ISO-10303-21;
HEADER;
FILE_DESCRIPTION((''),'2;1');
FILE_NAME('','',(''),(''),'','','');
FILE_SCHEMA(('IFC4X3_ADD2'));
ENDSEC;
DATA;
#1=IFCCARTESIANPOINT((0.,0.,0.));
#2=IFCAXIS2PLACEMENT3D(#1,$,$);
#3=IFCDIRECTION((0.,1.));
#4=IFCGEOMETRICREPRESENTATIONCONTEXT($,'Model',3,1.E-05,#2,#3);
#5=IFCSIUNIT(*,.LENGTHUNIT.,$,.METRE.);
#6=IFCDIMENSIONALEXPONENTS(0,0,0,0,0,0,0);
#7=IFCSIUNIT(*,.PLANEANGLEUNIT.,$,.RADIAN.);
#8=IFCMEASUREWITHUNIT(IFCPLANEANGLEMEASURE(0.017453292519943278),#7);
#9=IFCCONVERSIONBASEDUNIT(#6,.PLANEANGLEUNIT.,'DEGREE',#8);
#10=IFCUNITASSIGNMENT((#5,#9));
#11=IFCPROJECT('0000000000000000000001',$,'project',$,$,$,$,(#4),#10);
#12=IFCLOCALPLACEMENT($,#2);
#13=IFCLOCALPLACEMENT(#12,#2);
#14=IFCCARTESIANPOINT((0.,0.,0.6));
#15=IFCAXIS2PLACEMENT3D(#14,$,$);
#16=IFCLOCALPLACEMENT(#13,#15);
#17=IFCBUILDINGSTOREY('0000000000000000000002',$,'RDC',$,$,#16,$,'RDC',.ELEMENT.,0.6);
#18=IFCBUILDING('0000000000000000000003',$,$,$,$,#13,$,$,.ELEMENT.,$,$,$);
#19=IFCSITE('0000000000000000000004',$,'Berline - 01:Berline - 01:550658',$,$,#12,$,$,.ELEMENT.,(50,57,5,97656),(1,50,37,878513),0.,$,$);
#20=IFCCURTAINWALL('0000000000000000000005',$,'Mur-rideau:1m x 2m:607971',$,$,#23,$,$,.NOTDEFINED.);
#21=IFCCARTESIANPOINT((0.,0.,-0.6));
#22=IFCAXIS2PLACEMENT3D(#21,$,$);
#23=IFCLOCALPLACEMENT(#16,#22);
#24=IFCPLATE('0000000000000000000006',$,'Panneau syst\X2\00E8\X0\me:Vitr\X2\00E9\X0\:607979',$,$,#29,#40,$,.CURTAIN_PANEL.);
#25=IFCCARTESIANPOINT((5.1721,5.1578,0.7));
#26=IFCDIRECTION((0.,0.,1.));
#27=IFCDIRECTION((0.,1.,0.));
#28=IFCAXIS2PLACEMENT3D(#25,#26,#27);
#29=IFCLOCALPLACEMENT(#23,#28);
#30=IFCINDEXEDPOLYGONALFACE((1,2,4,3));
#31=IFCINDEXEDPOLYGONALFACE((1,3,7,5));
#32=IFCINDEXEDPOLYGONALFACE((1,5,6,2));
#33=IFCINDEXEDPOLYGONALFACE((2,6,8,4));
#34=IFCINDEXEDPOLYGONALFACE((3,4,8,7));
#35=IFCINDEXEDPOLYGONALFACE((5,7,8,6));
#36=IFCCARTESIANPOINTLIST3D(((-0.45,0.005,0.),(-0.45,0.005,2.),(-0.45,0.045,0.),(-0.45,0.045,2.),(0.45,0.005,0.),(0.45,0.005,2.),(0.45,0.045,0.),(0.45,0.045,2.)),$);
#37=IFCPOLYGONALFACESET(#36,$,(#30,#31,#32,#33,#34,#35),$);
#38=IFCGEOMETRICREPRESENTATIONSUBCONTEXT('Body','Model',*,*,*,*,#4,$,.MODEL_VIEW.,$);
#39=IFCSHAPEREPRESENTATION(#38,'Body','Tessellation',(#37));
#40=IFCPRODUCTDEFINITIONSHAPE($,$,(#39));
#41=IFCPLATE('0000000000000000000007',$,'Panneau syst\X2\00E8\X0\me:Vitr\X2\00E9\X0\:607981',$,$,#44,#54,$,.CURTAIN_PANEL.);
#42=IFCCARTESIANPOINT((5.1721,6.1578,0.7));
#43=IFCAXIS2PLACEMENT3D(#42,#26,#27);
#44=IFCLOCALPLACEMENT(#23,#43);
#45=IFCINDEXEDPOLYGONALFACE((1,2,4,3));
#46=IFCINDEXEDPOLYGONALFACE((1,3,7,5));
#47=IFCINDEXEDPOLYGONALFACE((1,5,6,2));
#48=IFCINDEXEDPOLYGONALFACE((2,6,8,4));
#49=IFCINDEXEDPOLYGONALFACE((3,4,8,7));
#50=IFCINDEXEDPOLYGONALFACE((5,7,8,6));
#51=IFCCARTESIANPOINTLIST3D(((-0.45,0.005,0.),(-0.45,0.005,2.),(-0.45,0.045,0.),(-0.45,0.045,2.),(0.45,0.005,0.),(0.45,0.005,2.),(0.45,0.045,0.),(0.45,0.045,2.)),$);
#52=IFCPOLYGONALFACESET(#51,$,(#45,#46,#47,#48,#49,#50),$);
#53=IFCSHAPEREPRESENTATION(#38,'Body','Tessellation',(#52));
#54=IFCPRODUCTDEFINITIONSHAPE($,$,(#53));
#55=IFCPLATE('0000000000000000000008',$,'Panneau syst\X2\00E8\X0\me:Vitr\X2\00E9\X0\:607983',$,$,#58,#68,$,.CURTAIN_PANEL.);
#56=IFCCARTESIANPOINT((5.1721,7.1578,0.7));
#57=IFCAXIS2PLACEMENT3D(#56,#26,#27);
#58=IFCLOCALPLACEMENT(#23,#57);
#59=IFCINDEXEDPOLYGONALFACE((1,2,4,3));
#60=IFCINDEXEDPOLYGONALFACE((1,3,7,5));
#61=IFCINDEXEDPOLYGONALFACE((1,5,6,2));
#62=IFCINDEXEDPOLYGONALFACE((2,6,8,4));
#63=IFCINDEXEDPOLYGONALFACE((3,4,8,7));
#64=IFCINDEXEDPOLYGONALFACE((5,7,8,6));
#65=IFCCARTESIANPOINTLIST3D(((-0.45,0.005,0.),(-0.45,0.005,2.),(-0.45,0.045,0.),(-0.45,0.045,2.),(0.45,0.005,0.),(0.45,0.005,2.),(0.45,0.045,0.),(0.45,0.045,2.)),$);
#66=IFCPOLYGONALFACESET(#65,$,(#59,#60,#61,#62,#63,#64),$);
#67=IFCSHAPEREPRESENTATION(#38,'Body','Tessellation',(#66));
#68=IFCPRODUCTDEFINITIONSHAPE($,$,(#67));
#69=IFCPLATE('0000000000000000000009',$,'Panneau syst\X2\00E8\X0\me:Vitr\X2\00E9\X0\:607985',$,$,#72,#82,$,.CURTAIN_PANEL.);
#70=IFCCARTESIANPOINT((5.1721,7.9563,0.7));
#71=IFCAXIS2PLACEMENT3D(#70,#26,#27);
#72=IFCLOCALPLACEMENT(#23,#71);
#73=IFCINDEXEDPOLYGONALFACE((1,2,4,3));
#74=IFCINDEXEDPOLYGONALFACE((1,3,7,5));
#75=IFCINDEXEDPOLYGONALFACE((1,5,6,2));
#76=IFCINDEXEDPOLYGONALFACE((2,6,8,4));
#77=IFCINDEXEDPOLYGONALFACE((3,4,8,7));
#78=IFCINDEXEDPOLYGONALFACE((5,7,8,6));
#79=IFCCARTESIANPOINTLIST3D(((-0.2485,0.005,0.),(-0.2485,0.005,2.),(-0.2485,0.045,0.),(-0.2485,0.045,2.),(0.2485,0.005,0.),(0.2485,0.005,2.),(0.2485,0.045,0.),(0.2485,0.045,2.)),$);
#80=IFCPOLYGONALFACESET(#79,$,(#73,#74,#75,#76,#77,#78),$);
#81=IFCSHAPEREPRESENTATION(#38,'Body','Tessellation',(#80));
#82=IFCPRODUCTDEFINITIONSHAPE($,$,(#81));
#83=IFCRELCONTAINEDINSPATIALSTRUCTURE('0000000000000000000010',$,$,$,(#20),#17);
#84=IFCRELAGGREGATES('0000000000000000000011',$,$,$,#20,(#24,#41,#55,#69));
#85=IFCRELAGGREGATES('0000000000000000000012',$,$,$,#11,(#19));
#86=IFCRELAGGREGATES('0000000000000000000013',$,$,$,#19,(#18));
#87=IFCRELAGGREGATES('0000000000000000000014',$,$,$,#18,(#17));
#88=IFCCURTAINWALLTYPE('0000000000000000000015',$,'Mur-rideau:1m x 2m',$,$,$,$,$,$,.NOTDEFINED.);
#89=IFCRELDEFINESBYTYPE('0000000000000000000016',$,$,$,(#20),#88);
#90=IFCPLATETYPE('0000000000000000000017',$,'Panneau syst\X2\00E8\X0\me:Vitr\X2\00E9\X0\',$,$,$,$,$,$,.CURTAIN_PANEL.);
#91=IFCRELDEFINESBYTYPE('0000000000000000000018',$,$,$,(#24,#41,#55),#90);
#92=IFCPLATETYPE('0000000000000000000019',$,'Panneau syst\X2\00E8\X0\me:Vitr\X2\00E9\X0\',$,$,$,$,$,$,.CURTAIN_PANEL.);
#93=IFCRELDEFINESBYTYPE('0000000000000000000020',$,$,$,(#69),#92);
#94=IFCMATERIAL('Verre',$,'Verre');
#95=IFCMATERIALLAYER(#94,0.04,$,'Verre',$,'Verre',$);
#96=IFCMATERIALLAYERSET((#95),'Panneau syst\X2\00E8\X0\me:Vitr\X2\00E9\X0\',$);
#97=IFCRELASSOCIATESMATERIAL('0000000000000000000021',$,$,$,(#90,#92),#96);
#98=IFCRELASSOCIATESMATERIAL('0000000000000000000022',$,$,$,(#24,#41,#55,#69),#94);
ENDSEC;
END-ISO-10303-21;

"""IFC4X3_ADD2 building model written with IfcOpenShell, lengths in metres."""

from ifc_helpers import new_model, entity, si_unit, converted_unit, direction, frame, frame_2d, origin, place, context, subcontext, project, spatial, rectangle, extrude, source, transform, mapped, material, layer, layer_set, type_object, type_shapes, element, aggregate, save


model = new_model("IFC4X3_ADD2")

# Units and contexts
model_context = context("Model", 3, precision=1e-05, world=origin(), true_north=direction((0.0, 1.0)))
body_context = subcontext(model_context, "Body", "Model", "MODEL_VIEW")
ifc_project = project(units=[si_unit("LENGTHUNIT", "METRE"), converted_unit("PLANEANGLEUNIT", "DEGREE", entity("IfcPlaneAngleMeasure", 0.017453292519943278), si_unit("PLANEANGLEUNIT", "RADIAN"), dimensions=[0, 0, 0, 0, 0, 0, 0])], contexts=[model_context])

# Site, building, storey
site_placement = place(None, origin())
site = spatial("IfcSite", under=ifc_project, at=site_placement, Name="Berline - 01:Berline - 01:550658", CompositionType="ELEMENT", RefLatitude=(50, 57, 5, 97656), RefLongitude=(1, 50, 37, 878513), RefElevation=0.0)
building_placement = place(site_placement, origin())
building = spatial("IfcBuilding", under=site, at=building_placement, CompositionType="ELEMENT")
storey_placement = place(building_placement, frame((0.0, 0.0, 0.6)))
storey = spatial("IfcBuildingStorey", under=building, at=storey_placement, Name="RDC", LongName="RDC", CompositionType="ELEMENT", Elevation=0.6)

# Curtain wall, plates
curtain_wall_type = type_object("IfcCurtainWallType", Name="Mur-rideau:1m x 2m", PredefinedType="NOTDEFINED")
curtain_wall_placement = place(storey_placement, frame((0.0, 0.0, -0.6)))
curtain_wall = element("IfcCurtainWall", 1, at=curtain_wall_placement, inside=storey, type_object=curtain_wall_type, Name="Mur-rideau:1m x 2m:607971", PredefinedType="NOTDEFINED")
ifc_material_1 = material(Name="Verre", Category="Verre")
ifc_layer_1 = layer(ifc_material_1, 0.04, Name="Verre", Category="Verre")
ifc_layer_set_1 = layer_set([ifc_layer_1], Name="Panneau système:Vitré")
plate_type_1 = type_object("IfcPlateType", Name="Panneau système:Vitré", PredefinedType="CURTAIN_PANEL", material=ifc_layer_set_1)
shared_shape_1 = source(origin(), body_context, "Body", "SweptSolid", [
    extrude(rectangle(XDim=0.04, YDim=0.9, at=frame_2d((0.0, 0.0), x_axis=(1.0, 0.0))), frame((0.0, 0.025, 0.0), z_axis=(0.0, 0.0, 1.0), x_axis=(0.0, 1.0, 0.0)), (0.0, 0.0, 1.0), 2.0),
])
type_shapes(plate_type_1, [shared_shape_1])
plate_1_placement = place(curtain_wall_placement, frame((5.1721, 5.1578, 0.7), z_axis=(0.0, 0.0, 1.0), x_axis=(0.0, 1.0, 0.0)))
plate_1 = element("IfcPlate", 2, at=plate_1_placement, type_object=plate_type_1, material=ifc_material_1, Name="Panneau système:Vitré:607979", PredefinedType="CURTAIN_PANEL", context=body_context, shape_type="MappedRepresentation", body=[
    mapped(shared_shape_1, transform((0.0, 0.0, 0.0), scale=1.0)),
])
plate_2_placement = place(curtain_wall_placement, frame((5.1721, 6.1578, 0.7), z_axis=(0.0, 0.0, 1.0), x_axis=(0.0, 1.0, 0.0)))
plate_2 = element("IfcPlate", 3, at=plate_2_placement, type_object=plate_type_1, material=ifc_material_1, Name="Panneau système:Vitré:607981", PredefinedType="CURTAIN_PANEL", context=body_context, shape_type="MappedRepresentation", body=[
    mapped(shared_shape_1, transform((0.0, 0.0, 0.0), scale=1.0)),
])
plate_3_placement = place(curtain_wall_placement, frame((5.1721, 7.1578, 0.7), z_axis=(0.0, 0.0, 1.0), x_axis=(0.0, 1.0, 0.0)))
plate_3 = element("IfcPlate", 4, at=plate_3_placement, type_object=plate_type_1, material=ifc_material_1, Name="Panneau système:Vitré:607983", PredefinedType="CURTAIN_PANEL", context=body_context, shape_type="MappedRepresentation", body=[
    mapped(shared_shape_1, transform((0.0, 0.0, 0.0), scale=1.0)),
])
plate_type_2 = type_object("IfcPlateType", Name="Panneau système:Vitré", PredefinedType="CURTAIN_PANEL", material=ifc_layer_set_1)
shared_shape_2 = source(origin(), body_context, "Body", "SweptSolid", [
    extrude(rectangle(XDim=0.04, YDim=0.497, at=frame_2d((0.0, 0.0), x_axis=(1.0, 0.0))), frame((0.0, 0.025, 0.0), z_axis=(0.0, 0.0, 1.0), x_axis=(0.0, 1.0, 0.0)), (0.0, 0.0, 1.0), 2.0),
])
type_shapes(plate_type_2, [shared_shape_2])
plate_4_placement = place(curtain_wall_placement, frame((5.1721, 7.9563, 0.7), z_axis=(0.0, 0.0, 1.0), x_axis=(0.0, 1.0, 0.0)))
plate_4 = element("IfcPlate", 5, at=plate_4_placement, type_object=plate_type_2, material=ifc_material_1, Name="Panneau système:Vitré:607985", PredefinedType="CURTAIN_PANEL", context=body_context, shape_type="MappedRepresentation", body=[
    mapped(shared_shape_2, transform((0.0, 0.0, 0.0), scale=1.0)),
])
aggregate(curtain_wall, [plate_1, plate_2, plate_3, plate_4])

save(model, "model.ifc")
